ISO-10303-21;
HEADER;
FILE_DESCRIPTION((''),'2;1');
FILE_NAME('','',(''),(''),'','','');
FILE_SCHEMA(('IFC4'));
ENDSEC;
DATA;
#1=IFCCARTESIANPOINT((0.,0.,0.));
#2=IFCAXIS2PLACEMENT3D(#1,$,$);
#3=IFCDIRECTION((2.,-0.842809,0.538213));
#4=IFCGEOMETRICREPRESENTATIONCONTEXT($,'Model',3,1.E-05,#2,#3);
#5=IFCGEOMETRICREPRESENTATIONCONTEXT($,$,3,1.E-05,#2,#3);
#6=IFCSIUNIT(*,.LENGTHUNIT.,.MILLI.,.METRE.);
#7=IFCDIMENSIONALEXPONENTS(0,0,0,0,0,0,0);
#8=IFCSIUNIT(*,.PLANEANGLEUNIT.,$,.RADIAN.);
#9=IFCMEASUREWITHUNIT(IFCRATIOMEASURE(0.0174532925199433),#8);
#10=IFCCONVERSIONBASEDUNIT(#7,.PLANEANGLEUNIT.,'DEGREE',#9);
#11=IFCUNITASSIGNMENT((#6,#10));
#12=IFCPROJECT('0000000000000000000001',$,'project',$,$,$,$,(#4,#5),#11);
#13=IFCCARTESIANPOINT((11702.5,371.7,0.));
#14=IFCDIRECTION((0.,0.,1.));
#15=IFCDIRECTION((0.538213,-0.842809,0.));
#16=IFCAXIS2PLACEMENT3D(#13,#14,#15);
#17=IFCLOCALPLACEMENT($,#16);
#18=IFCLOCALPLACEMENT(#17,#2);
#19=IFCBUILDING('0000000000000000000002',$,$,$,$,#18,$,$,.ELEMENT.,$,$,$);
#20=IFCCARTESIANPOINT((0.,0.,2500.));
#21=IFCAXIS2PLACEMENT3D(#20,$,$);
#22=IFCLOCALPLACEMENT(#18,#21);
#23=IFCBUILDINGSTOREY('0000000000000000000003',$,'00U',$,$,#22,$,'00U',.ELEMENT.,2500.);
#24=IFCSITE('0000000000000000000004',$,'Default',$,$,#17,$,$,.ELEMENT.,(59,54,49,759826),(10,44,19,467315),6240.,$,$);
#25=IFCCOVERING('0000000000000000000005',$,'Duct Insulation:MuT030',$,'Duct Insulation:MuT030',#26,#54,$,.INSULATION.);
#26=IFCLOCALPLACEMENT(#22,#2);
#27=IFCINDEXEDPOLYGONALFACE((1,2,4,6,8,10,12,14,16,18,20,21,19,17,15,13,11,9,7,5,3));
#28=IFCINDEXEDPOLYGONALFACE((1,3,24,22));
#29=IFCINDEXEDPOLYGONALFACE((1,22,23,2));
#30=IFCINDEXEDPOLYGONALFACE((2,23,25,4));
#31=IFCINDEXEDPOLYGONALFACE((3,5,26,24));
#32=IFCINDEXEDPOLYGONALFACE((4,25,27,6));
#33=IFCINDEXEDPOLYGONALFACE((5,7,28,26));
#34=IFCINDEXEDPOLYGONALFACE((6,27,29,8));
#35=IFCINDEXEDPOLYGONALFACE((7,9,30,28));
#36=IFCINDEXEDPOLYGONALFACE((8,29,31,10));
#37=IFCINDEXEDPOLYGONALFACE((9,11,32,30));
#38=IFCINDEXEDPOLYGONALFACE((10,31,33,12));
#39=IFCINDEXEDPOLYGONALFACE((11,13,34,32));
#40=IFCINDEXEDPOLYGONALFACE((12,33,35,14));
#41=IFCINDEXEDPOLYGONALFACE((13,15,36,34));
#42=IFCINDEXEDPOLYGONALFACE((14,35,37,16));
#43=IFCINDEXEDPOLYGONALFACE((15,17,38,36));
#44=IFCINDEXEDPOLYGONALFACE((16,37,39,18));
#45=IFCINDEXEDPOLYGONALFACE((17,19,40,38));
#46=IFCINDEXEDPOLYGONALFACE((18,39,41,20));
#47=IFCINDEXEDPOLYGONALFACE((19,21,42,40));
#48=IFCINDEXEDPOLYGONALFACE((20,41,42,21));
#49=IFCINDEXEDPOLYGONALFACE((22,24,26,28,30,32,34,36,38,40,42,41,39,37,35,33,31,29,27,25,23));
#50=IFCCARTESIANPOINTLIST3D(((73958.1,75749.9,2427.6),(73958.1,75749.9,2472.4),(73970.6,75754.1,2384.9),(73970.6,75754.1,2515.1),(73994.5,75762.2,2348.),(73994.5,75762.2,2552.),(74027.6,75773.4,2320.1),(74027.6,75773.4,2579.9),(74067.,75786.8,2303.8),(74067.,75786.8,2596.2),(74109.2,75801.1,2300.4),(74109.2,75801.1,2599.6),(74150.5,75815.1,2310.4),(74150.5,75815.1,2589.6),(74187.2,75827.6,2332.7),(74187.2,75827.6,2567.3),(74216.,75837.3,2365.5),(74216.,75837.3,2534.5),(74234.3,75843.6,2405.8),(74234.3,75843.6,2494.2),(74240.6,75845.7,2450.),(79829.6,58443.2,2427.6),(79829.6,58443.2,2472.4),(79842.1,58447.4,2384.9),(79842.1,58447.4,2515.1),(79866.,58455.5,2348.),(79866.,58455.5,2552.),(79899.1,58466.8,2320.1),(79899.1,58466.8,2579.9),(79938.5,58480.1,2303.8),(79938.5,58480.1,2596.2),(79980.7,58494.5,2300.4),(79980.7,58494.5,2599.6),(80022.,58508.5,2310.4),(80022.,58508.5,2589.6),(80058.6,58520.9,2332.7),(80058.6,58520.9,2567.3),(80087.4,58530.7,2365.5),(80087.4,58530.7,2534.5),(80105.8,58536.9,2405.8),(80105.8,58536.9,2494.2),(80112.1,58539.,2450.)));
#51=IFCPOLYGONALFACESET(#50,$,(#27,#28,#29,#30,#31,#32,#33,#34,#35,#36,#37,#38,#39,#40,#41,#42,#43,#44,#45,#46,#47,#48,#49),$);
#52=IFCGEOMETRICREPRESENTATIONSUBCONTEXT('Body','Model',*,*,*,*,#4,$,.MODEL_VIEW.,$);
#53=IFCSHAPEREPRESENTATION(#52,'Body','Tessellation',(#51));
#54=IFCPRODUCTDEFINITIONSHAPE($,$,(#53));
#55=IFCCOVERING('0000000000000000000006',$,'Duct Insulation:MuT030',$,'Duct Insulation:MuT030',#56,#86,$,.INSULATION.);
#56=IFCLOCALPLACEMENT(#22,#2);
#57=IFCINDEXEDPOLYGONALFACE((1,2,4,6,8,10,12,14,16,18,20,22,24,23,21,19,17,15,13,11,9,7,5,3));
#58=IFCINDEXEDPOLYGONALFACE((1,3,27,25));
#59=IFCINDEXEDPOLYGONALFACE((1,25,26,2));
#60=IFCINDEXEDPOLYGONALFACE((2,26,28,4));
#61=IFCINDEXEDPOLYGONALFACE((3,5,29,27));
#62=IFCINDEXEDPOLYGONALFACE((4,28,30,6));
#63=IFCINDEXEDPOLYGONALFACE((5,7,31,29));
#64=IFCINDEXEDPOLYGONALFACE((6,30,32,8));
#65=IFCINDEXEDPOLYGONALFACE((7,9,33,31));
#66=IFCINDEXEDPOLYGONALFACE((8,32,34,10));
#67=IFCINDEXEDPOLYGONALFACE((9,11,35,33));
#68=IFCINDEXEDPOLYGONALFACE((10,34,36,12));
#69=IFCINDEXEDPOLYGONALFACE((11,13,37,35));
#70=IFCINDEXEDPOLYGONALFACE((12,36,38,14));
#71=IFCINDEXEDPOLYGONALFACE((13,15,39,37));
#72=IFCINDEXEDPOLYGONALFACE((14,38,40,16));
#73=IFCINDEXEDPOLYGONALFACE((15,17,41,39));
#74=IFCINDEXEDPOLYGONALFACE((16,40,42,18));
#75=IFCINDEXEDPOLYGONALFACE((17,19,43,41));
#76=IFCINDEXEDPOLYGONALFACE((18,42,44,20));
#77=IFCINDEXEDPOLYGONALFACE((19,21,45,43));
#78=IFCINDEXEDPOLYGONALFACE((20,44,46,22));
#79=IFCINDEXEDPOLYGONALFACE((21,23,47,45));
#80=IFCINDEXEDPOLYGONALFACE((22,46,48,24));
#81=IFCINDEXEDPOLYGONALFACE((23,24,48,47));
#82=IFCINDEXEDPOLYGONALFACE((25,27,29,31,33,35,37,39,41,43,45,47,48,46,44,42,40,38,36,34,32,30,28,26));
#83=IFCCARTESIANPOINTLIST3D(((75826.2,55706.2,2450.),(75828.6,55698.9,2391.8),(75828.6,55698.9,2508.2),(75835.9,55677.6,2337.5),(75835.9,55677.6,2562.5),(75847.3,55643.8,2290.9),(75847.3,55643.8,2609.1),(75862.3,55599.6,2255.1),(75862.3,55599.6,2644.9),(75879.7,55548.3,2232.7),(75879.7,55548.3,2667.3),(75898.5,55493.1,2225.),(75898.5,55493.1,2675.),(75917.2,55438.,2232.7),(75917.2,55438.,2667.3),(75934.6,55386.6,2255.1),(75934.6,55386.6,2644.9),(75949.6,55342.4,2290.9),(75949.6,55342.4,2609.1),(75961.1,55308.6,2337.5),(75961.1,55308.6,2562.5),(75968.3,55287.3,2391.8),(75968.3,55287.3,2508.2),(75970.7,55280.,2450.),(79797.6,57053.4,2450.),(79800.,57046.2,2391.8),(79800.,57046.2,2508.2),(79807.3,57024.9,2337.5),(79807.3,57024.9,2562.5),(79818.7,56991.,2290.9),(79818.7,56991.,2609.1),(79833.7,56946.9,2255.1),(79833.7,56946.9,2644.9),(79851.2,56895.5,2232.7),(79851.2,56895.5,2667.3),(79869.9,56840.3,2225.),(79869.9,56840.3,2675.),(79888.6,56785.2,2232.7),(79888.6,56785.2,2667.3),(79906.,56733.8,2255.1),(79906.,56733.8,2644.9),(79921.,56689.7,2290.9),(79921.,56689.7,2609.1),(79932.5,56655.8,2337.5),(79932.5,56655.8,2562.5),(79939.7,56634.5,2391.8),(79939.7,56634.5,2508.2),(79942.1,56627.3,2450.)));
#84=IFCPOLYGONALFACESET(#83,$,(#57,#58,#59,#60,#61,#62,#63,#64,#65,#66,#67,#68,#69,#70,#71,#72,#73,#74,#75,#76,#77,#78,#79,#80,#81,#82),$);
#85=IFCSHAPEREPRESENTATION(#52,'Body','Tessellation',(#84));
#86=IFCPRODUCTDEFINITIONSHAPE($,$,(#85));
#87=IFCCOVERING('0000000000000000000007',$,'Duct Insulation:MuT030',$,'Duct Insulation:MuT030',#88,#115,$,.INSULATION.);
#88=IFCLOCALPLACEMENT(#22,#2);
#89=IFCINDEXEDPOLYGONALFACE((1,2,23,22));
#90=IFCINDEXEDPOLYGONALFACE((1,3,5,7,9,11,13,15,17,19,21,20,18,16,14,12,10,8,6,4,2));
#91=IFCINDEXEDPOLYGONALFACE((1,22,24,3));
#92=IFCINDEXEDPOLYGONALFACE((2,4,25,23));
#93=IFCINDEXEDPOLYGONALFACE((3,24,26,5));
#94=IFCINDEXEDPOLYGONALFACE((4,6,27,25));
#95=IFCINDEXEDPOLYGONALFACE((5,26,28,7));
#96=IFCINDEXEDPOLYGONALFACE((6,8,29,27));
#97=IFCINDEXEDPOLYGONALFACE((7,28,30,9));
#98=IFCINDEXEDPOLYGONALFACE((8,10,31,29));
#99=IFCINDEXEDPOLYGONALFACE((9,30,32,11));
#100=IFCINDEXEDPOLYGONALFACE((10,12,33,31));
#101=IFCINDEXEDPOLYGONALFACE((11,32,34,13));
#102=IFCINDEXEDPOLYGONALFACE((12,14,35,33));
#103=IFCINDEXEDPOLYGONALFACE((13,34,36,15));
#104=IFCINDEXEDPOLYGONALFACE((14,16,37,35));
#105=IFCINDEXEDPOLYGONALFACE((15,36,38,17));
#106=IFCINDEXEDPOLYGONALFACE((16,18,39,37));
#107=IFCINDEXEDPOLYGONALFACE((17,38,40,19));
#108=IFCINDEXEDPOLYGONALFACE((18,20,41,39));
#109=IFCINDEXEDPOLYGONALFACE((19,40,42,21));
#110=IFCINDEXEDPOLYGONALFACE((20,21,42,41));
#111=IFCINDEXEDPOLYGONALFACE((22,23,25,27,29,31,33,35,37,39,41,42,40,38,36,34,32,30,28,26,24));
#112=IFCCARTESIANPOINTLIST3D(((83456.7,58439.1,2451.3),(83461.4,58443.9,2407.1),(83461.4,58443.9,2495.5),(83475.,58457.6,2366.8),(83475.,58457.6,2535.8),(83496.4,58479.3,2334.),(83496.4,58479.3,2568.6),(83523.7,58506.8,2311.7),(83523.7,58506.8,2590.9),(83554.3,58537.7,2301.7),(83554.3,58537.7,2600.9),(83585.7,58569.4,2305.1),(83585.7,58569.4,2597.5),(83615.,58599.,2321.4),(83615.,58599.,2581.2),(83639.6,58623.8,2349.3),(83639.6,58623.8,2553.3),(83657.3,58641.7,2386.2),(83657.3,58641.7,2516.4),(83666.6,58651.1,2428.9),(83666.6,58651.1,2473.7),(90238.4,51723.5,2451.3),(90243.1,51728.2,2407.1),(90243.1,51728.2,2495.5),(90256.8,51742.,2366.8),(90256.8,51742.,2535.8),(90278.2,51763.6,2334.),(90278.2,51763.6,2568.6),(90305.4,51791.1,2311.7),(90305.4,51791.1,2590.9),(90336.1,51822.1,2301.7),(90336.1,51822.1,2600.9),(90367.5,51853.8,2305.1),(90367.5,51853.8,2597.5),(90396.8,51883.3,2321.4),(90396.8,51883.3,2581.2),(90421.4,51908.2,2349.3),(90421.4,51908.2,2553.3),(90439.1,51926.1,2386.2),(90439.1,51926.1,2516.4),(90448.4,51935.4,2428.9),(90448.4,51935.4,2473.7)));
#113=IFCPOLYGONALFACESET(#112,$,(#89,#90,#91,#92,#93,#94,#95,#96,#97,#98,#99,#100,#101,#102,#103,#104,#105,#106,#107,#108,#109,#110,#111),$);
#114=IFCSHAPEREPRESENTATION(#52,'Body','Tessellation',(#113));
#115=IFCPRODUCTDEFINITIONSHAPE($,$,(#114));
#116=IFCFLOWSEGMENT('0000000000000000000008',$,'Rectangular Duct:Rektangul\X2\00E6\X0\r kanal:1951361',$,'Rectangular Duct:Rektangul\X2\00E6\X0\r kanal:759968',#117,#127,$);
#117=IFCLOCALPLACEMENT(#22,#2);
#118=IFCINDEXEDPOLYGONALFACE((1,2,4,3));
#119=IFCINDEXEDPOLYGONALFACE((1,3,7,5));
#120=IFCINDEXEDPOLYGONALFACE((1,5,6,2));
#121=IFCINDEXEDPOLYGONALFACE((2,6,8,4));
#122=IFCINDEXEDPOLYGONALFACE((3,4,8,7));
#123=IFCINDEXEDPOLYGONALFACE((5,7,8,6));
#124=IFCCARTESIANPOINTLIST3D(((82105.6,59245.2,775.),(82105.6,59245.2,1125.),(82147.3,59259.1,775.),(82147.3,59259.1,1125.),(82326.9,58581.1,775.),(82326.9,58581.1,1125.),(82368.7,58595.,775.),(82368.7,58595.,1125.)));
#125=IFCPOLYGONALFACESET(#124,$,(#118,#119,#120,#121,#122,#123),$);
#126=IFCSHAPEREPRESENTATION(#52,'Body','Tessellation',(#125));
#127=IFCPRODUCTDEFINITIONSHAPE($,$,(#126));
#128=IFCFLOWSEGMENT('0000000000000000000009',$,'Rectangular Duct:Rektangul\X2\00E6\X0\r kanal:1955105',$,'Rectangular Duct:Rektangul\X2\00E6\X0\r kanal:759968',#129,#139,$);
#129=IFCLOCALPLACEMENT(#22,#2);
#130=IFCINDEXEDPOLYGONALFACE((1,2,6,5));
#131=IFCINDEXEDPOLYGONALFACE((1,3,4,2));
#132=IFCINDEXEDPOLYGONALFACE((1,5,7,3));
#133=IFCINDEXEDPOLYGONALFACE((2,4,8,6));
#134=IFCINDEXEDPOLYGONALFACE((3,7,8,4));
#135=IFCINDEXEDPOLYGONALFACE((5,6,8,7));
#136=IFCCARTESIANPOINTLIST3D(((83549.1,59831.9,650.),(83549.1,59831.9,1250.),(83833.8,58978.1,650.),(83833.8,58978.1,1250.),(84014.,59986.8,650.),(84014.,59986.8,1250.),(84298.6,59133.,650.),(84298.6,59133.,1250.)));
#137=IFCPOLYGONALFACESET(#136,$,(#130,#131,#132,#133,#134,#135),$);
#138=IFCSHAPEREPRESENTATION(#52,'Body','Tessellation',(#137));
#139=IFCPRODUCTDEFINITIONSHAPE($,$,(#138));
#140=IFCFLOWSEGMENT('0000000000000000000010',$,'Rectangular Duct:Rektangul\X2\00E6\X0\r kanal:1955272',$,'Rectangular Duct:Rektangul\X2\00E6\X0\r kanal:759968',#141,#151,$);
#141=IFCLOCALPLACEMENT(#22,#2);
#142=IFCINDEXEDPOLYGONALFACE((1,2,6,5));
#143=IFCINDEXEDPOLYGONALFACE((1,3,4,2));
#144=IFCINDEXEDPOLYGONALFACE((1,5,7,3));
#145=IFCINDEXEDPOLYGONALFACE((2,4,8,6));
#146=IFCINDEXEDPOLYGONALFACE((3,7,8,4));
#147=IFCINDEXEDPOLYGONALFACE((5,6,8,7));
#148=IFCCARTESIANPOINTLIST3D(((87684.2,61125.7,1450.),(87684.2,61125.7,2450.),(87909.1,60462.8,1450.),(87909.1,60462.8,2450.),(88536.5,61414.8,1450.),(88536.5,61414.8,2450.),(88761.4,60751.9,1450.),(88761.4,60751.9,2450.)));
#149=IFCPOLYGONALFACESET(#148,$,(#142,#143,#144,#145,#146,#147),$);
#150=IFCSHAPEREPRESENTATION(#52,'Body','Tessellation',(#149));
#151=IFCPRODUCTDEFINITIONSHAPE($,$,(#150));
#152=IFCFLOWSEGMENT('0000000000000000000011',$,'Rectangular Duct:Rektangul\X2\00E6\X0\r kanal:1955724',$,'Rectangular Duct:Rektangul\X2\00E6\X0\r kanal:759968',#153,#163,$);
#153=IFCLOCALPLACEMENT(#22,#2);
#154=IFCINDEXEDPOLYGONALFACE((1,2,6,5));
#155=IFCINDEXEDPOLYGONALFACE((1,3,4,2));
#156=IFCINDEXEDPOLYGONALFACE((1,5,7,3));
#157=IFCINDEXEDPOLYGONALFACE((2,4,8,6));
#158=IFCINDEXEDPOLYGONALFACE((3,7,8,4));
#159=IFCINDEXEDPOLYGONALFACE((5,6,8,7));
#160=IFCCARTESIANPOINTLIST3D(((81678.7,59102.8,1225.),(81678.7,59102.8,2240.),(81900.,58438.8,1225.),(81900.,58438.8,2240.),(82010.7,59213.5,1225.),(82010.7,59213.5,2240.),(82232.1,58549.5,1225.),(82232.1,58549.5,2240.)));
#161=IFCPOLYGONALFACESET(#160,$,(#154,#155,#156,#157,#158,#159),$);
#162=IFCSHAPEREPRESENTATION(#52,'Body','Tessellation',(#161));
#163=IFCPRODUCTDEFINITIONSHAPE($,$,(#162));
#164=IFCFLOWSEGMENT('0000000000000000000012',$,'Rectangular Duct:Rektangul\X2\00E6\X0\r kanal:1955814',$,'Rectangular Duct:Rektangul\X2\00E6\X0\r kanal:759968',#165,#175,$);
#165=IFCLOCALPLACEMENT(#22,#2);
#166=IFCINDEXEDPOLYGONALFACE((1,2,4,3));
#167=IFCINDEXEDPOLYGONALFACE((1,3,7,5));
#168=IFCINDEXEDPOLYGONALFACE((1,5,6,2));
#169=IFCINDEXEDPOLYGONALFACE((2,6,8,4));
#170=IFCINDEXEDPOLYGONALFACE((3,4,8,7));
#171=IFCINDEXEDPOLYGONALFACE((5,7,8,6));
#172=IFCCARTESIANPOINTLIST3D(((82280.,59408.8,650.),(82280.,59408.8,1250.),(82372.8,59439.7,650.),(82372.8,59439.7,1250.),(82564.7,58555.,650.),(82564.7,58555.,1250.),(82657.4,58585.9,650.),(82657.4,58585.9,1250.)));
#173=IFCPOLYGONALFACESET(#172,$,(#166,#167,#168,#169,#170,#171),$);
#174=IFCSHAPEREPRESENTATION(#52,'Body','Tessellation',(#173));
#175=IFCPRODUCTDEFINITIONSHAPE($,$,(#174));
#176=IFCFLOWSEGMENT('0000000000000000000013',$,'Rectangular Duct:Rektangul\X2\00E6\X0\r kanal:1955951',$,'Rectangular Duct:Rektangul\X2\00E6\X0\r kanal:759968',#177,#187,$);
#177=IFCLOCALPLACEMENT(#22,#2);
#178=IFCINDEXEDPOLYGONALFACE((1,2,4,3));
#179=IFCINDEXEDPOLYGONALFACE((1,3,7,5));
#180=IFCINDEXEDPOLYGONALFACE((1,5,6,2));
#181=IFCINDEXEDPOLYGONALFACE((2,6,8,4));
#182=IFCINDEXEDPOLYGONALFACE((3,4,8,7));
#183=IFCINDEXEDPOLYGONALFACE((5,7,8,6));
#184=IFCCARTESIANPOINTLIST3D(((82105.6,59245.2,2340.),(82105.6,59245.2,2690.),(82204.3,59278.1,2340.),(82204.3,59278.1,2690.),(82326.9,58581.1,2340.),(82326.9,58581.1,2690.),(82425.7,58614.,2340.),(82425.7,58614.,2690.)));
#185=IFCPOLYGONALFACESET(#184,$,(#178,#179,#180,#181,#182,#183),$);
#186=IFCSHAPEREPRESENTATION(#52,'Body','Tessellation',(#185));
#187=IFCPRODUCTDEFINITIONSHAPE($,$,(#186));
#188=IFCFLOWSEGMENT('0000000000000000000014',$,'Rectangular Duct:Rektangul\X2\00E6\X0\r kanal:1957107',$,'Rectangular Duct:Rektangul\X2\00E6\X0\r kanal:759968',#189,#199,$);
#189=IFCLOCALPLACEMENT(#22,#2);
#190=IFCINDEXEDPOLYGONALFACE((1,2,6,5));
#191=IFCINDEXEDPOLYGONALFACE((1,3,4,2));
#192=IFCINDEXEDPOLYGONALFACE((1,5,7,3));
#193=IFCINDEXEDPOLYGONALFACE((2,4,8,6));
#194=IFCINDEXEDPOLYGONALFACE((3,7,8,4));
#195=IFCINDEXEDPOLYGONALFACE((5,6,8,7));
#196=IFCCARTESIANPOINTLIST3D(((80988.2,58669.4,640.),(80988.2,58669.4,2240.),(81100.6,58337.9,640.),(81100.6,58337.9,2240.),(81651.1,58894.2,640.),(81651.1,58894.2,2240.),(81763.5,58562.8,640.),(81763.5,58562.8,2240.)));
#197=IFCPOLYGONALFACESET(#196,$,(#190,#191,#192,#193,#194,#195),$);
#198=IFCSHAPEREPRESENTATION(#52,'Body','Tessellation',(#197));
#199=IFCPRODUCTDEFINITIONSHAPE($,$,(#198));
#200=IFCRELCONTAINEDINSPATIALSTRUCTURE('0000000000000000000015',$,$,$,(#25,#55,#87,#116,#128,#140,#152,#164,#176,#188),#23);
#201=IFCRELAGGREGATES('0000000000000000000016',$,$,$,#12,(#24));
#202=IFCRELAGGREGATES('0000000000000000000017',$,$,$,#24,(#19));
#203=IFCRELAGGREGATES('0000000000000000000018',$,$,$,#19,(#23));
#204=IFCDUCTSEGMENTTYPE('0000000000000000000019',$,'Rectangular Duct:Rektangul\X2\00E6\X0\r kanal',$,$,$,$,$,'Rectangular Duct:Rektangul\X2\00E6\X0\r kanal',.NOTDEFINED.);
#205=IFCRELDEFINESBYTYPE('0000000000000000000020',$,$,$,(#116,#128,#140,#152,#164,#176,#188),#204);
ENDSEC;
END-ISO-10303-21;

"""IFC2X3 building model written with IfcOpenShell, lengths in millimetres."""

from ifc_helpers import new_model, entity, si_unit, converted_unit, direction, frame, frame_2d, origin, origin_2d_with_axis, place, context, subcontext, project, spatial, rectangle, circle, extrude, type_object, element, save


model = new_model("IFC2X3")

# Units and contexts
model_context = context("Model", 3, precision=1e-05, world=origin(), true_north=direction((2.0, -0.842809, 0.538213)))
context_of_model = context(None, 3, precision=1e-05, world=origin(), true_north=direction((2.0, -0.842809, 0.538213)))
body_context = subcontext(model_context, "Body", "Model", "MODEL_VIEW")
ifc_project = project(units=[si_unit("LENGTHUNIT", "METRE", prefix="MILLI"), converted_unit("PLANEANGLEUNIT", "DEGREE", entity("IfcRatioMeasure", 0.0174532925199433), si_unit("PLANEANGLEUNIT", "RADIAN"), dimensions=[0, 0, 0, 0, 0, 0, 0])], contexts=[model_context, context_of_model])

# Site, building, storey
site_placement = place(None, frame((11702.5, 371.7, 0.0), z_axis=(0.0, 0.0, 1.0), x_axis=(0.538213, -0.842809, 0.0)))
site = spatial("IfcSite", under=ifc_project, at=site_placement, Name="Default", CompositionType="ELEMENT", RefLatitude=(59, 54, 49, 759826), RefLongitude=(10, 44, 19, 467315), RefElevation=6240.0)
building_placement = place(site_placement, origin())
building = spatial("IfcBuilding", under=site, at=building_placement, CompositionType="ELEMENT")
storey_placement = place(building_placement, frame((0.0, 0.0, 2500.0)))
storey = spatial("IfcBuildingStorey", under=building, at=storey_placement, Name="00U", LongName="00U", CompositionType="ELEMENT", Elevation=2500.0)

# Coverings
covering_1_placement = place(storey_placement, origin())
element("IfcCovering", 1, at=covering_1_placement, inside=storey, Name="Duct Insulation:MuT030", ObjectType="Duct Insulation:MuT030", PredefinedType="INSULATION", context=body_context, shape_type="SweptSolid", body=[
    extrude(circle(Radius=150.0, at=origin_2d_with_axis()), frame((74098.6, 75797.5, 2450.0), z_axis=(0.321276, -0.946986, 0.0), x_axis=(0.946986, 0.321276, 0.0)), (0.0, 0.0, 1.0), 18275.5),
])
covering_2_placement = place(storey_placement, origin())
element("IfcCovering", 2, at=covering_2_placement, inside=storey, Name="Duct Insulation:MuT030", ObjectType="Duct Insulation:MuT030", PredefinedType="INSULATION", context=body_context, shape_type="SweptSolid", body=[
    extrude(circle(Radius=225.0, at=origin_2d_with_axis()), frame((75898.5, 55493.1, 2450.0), z_axis=(0.946993, 0.321254, 0.0), x_axis=(-0.321254, 0.946993, 0.0)), (0.0, 0.0, 1.0), 4193.7),
])
covering_3_placement = place(storey_placement, origin())
element("IfcCovering", 3, at=covering_3_placement, inside=storey, Name="Duct Insulation:MuT030", ObjectType="Duct Insulation:MuT030", PredefinedType="INSULATION", context=body_context, shape_type="SweptSolid", body=[
    extrude(circle(Radius=150.0, at=origin_2d_with_axis()), frame((83562.2, 58545.7, 2451.3), z_axis=(0.710561, -0.703635, 0.0), x_axis=(-0.703635, -0.710561, 0.0)), (0.0, 0.0, 1.0), 9544.2),
])

# Flow segments
duct_segment_type_1 = type_object("IfcDuctSegmentType", Name="Rectangular Duct:Rektangulær kanal", ElementType="Rectangular Duct:Rektangulær kanal", PredefinedType="NOTDEFINED")
flow_segment_1_placement = place(storey_placement, origin())
element("IfcFlowSegment", 4, at=flow_segment_1_placement, inside=storey, type_object=duct_segment_type_1, Name="Rectangular Duct:Rektangulær kanal:1951361", ObjectType="Rectangular Duct:Rektangulær kanal:759968", context=body_context, shape_type="SweptSolid", body=[
    extrude(rectangle(XDim=44.1, YDim=700.0, at=frame_2d((0.0, 0.0), x_axis=(1.0, 0.0))), frame((82237.1, 58920.1, 775.0), z_axis=(0.0, 0.0, 1.0), x_axis=(-0.948667, -0.316277, 0.0)), (0.0, 0.0, 1.0), 350.0),
])
flow_segment_2_placement = place(storey_placement, origin())
element("IfcFlowSegment", 5, at=flow_segment_2_placement, inside=storey, type_object=duct_segment_type_1, Name="Rectangular Duct:Rektangulær kanal:1955105", ObjectType="Rectangular Duct:Rektangulær kanal:759968", context=body_context, shape_type="SweptSolid", body=[
    extrude(rectangle(XDim=490.0, YDim=900.0, at=frame_2d((0.0, 0.0), x_axis=(1.0, 0.0))), frame((83923.9, 59482.4, 650.0), z_axis=(0.0, 0.0, 1.0), x_axis=(-0.948667, -0.316277, 0.0)), (0.0, 0.0, 1.0), 600.0),
])
flow_segment_3_placement = place(storey_placement, origin())
element("IfcFlowSegment", 6, at=flow_segment_3_placement, inside=storey, type_object=duct_segment_type_1, Name="Rectangular Duct:Rektangulær kanal:1955272", ObjectType="Rectangular Duct:Rektangulær kanal:759968", context=body_context, shape_type="SweptSolid", body=[
    extrude(rectangle(XDim=900.0, YDim=700.0, at=frame_2d((0.0, 0.0), x_axis=(1.0, 0.0))), frame((88222.8, 60938.8, 1450.0), z_axis=(0.0, 0.0, 1.0), x_axis=(-0.946996, -0.321246, 0.0)), (0.0, 0.0, 1.0), 1000.0),
])
flow_segment_4_placement = place(storey_placement, origin())
element("IfcFlowSegment", 7, at=flow_segment_4_placement, inside=storey, type_object=duct_segment_type_1, Name="Rectangular Duct:Rektangulær kanal:1955724", ObjectType="Rectangular Duct:Rektangulær kanal:759968", context=body_context, shape_type="SweptSolid", body=[
    extrude(rectangle(XDim=350.0, YDim=700.0, at=frame_2d((0.0, 0.0), x_axis=(1.0, 0.0))), frame((81955.4, 58826.2, 1225.0), z_axis=(0.0, 0.0, 1.0), x_axis=(0.948667, 0.316277, 0.0)), (0.0, 0.0, 1.0), 1015.0),
])
flow_segment_5_placement = place(storey_placement, origin())
element("IfcFlowSegment", 8, at=flow_segment_5_placement, inside=storey, type_object=duct_segment_type_1, Name="Rectangular Duct:Rektangulær kanal:1955814", ObjectType="Rectangular Duct:Rektangulær kanal:759968", context=body_context, shape_type="SweptSolid", body=[
    extrude(rectangle(XDim=97.8, YDim=900.0, at=frame_2d((0.0, 0.0), x_axis=(1.0, 0.0))), frame((82468.7, 58997.3, 650.0), z_axis=(0.0, 0.0, 1.0), x_axis=(0.948667, 0.316277, 0.0)), (0.0, 0.0, 1.0), 600.0),
])
flow_segment_6_placement = place(storey_placement, origin())
element("IfcFlowSegment", 9, at=flow_segment_6_placement, inside=storey, type_object=duct_segment_type_1, Name="Rectangular Duct:Rektangulær kanal:1955951", ObjectType="Rectangular Duct:Rektangulær kanal:759968", context=body_context, shape_type="SweptSolid", body=[
    extrude(rectangle(XDim=104.1, YDim=700.0, at=frame_2d((0.0, 0.0), x_axis=(1.0, 0.0))), frame((82265.6, 58929.6, 2340.0), z_axis=(0.0, 0.0, 1.0), x_axis=(0.948667, 0.316277, 0.0)), (0.0, 0.0, 1.0), 350.0),
])
flow_segment_7_placement = place(storey_placement, origin())
element("IfcFlowSegment", 10, at=flow_segment_7_placement, inside=storey, type_object=duct_segment_type_1, Name="Rectangular Duct:Rektangulær kanal:1957107", ObjectType="Rectangular Duct:Rektangulær kanal:759968", context=body_context, shape_type="SweptSolid", body=[
    extrude(rectangle(XDim=350.0, YDim=700.0, at=frame_2d((0.0, 0.0), x_axis=(1.0, 0.0))), frame((81375.8, 58616.1, 640.0), z_axis=(0.0, 0.0, 1.0), x_axis=(0.321246, -0.946996, 0.0)), (0.0, 0.0, 1.0), 1600.0),
])

save(model, "model.ifc")
